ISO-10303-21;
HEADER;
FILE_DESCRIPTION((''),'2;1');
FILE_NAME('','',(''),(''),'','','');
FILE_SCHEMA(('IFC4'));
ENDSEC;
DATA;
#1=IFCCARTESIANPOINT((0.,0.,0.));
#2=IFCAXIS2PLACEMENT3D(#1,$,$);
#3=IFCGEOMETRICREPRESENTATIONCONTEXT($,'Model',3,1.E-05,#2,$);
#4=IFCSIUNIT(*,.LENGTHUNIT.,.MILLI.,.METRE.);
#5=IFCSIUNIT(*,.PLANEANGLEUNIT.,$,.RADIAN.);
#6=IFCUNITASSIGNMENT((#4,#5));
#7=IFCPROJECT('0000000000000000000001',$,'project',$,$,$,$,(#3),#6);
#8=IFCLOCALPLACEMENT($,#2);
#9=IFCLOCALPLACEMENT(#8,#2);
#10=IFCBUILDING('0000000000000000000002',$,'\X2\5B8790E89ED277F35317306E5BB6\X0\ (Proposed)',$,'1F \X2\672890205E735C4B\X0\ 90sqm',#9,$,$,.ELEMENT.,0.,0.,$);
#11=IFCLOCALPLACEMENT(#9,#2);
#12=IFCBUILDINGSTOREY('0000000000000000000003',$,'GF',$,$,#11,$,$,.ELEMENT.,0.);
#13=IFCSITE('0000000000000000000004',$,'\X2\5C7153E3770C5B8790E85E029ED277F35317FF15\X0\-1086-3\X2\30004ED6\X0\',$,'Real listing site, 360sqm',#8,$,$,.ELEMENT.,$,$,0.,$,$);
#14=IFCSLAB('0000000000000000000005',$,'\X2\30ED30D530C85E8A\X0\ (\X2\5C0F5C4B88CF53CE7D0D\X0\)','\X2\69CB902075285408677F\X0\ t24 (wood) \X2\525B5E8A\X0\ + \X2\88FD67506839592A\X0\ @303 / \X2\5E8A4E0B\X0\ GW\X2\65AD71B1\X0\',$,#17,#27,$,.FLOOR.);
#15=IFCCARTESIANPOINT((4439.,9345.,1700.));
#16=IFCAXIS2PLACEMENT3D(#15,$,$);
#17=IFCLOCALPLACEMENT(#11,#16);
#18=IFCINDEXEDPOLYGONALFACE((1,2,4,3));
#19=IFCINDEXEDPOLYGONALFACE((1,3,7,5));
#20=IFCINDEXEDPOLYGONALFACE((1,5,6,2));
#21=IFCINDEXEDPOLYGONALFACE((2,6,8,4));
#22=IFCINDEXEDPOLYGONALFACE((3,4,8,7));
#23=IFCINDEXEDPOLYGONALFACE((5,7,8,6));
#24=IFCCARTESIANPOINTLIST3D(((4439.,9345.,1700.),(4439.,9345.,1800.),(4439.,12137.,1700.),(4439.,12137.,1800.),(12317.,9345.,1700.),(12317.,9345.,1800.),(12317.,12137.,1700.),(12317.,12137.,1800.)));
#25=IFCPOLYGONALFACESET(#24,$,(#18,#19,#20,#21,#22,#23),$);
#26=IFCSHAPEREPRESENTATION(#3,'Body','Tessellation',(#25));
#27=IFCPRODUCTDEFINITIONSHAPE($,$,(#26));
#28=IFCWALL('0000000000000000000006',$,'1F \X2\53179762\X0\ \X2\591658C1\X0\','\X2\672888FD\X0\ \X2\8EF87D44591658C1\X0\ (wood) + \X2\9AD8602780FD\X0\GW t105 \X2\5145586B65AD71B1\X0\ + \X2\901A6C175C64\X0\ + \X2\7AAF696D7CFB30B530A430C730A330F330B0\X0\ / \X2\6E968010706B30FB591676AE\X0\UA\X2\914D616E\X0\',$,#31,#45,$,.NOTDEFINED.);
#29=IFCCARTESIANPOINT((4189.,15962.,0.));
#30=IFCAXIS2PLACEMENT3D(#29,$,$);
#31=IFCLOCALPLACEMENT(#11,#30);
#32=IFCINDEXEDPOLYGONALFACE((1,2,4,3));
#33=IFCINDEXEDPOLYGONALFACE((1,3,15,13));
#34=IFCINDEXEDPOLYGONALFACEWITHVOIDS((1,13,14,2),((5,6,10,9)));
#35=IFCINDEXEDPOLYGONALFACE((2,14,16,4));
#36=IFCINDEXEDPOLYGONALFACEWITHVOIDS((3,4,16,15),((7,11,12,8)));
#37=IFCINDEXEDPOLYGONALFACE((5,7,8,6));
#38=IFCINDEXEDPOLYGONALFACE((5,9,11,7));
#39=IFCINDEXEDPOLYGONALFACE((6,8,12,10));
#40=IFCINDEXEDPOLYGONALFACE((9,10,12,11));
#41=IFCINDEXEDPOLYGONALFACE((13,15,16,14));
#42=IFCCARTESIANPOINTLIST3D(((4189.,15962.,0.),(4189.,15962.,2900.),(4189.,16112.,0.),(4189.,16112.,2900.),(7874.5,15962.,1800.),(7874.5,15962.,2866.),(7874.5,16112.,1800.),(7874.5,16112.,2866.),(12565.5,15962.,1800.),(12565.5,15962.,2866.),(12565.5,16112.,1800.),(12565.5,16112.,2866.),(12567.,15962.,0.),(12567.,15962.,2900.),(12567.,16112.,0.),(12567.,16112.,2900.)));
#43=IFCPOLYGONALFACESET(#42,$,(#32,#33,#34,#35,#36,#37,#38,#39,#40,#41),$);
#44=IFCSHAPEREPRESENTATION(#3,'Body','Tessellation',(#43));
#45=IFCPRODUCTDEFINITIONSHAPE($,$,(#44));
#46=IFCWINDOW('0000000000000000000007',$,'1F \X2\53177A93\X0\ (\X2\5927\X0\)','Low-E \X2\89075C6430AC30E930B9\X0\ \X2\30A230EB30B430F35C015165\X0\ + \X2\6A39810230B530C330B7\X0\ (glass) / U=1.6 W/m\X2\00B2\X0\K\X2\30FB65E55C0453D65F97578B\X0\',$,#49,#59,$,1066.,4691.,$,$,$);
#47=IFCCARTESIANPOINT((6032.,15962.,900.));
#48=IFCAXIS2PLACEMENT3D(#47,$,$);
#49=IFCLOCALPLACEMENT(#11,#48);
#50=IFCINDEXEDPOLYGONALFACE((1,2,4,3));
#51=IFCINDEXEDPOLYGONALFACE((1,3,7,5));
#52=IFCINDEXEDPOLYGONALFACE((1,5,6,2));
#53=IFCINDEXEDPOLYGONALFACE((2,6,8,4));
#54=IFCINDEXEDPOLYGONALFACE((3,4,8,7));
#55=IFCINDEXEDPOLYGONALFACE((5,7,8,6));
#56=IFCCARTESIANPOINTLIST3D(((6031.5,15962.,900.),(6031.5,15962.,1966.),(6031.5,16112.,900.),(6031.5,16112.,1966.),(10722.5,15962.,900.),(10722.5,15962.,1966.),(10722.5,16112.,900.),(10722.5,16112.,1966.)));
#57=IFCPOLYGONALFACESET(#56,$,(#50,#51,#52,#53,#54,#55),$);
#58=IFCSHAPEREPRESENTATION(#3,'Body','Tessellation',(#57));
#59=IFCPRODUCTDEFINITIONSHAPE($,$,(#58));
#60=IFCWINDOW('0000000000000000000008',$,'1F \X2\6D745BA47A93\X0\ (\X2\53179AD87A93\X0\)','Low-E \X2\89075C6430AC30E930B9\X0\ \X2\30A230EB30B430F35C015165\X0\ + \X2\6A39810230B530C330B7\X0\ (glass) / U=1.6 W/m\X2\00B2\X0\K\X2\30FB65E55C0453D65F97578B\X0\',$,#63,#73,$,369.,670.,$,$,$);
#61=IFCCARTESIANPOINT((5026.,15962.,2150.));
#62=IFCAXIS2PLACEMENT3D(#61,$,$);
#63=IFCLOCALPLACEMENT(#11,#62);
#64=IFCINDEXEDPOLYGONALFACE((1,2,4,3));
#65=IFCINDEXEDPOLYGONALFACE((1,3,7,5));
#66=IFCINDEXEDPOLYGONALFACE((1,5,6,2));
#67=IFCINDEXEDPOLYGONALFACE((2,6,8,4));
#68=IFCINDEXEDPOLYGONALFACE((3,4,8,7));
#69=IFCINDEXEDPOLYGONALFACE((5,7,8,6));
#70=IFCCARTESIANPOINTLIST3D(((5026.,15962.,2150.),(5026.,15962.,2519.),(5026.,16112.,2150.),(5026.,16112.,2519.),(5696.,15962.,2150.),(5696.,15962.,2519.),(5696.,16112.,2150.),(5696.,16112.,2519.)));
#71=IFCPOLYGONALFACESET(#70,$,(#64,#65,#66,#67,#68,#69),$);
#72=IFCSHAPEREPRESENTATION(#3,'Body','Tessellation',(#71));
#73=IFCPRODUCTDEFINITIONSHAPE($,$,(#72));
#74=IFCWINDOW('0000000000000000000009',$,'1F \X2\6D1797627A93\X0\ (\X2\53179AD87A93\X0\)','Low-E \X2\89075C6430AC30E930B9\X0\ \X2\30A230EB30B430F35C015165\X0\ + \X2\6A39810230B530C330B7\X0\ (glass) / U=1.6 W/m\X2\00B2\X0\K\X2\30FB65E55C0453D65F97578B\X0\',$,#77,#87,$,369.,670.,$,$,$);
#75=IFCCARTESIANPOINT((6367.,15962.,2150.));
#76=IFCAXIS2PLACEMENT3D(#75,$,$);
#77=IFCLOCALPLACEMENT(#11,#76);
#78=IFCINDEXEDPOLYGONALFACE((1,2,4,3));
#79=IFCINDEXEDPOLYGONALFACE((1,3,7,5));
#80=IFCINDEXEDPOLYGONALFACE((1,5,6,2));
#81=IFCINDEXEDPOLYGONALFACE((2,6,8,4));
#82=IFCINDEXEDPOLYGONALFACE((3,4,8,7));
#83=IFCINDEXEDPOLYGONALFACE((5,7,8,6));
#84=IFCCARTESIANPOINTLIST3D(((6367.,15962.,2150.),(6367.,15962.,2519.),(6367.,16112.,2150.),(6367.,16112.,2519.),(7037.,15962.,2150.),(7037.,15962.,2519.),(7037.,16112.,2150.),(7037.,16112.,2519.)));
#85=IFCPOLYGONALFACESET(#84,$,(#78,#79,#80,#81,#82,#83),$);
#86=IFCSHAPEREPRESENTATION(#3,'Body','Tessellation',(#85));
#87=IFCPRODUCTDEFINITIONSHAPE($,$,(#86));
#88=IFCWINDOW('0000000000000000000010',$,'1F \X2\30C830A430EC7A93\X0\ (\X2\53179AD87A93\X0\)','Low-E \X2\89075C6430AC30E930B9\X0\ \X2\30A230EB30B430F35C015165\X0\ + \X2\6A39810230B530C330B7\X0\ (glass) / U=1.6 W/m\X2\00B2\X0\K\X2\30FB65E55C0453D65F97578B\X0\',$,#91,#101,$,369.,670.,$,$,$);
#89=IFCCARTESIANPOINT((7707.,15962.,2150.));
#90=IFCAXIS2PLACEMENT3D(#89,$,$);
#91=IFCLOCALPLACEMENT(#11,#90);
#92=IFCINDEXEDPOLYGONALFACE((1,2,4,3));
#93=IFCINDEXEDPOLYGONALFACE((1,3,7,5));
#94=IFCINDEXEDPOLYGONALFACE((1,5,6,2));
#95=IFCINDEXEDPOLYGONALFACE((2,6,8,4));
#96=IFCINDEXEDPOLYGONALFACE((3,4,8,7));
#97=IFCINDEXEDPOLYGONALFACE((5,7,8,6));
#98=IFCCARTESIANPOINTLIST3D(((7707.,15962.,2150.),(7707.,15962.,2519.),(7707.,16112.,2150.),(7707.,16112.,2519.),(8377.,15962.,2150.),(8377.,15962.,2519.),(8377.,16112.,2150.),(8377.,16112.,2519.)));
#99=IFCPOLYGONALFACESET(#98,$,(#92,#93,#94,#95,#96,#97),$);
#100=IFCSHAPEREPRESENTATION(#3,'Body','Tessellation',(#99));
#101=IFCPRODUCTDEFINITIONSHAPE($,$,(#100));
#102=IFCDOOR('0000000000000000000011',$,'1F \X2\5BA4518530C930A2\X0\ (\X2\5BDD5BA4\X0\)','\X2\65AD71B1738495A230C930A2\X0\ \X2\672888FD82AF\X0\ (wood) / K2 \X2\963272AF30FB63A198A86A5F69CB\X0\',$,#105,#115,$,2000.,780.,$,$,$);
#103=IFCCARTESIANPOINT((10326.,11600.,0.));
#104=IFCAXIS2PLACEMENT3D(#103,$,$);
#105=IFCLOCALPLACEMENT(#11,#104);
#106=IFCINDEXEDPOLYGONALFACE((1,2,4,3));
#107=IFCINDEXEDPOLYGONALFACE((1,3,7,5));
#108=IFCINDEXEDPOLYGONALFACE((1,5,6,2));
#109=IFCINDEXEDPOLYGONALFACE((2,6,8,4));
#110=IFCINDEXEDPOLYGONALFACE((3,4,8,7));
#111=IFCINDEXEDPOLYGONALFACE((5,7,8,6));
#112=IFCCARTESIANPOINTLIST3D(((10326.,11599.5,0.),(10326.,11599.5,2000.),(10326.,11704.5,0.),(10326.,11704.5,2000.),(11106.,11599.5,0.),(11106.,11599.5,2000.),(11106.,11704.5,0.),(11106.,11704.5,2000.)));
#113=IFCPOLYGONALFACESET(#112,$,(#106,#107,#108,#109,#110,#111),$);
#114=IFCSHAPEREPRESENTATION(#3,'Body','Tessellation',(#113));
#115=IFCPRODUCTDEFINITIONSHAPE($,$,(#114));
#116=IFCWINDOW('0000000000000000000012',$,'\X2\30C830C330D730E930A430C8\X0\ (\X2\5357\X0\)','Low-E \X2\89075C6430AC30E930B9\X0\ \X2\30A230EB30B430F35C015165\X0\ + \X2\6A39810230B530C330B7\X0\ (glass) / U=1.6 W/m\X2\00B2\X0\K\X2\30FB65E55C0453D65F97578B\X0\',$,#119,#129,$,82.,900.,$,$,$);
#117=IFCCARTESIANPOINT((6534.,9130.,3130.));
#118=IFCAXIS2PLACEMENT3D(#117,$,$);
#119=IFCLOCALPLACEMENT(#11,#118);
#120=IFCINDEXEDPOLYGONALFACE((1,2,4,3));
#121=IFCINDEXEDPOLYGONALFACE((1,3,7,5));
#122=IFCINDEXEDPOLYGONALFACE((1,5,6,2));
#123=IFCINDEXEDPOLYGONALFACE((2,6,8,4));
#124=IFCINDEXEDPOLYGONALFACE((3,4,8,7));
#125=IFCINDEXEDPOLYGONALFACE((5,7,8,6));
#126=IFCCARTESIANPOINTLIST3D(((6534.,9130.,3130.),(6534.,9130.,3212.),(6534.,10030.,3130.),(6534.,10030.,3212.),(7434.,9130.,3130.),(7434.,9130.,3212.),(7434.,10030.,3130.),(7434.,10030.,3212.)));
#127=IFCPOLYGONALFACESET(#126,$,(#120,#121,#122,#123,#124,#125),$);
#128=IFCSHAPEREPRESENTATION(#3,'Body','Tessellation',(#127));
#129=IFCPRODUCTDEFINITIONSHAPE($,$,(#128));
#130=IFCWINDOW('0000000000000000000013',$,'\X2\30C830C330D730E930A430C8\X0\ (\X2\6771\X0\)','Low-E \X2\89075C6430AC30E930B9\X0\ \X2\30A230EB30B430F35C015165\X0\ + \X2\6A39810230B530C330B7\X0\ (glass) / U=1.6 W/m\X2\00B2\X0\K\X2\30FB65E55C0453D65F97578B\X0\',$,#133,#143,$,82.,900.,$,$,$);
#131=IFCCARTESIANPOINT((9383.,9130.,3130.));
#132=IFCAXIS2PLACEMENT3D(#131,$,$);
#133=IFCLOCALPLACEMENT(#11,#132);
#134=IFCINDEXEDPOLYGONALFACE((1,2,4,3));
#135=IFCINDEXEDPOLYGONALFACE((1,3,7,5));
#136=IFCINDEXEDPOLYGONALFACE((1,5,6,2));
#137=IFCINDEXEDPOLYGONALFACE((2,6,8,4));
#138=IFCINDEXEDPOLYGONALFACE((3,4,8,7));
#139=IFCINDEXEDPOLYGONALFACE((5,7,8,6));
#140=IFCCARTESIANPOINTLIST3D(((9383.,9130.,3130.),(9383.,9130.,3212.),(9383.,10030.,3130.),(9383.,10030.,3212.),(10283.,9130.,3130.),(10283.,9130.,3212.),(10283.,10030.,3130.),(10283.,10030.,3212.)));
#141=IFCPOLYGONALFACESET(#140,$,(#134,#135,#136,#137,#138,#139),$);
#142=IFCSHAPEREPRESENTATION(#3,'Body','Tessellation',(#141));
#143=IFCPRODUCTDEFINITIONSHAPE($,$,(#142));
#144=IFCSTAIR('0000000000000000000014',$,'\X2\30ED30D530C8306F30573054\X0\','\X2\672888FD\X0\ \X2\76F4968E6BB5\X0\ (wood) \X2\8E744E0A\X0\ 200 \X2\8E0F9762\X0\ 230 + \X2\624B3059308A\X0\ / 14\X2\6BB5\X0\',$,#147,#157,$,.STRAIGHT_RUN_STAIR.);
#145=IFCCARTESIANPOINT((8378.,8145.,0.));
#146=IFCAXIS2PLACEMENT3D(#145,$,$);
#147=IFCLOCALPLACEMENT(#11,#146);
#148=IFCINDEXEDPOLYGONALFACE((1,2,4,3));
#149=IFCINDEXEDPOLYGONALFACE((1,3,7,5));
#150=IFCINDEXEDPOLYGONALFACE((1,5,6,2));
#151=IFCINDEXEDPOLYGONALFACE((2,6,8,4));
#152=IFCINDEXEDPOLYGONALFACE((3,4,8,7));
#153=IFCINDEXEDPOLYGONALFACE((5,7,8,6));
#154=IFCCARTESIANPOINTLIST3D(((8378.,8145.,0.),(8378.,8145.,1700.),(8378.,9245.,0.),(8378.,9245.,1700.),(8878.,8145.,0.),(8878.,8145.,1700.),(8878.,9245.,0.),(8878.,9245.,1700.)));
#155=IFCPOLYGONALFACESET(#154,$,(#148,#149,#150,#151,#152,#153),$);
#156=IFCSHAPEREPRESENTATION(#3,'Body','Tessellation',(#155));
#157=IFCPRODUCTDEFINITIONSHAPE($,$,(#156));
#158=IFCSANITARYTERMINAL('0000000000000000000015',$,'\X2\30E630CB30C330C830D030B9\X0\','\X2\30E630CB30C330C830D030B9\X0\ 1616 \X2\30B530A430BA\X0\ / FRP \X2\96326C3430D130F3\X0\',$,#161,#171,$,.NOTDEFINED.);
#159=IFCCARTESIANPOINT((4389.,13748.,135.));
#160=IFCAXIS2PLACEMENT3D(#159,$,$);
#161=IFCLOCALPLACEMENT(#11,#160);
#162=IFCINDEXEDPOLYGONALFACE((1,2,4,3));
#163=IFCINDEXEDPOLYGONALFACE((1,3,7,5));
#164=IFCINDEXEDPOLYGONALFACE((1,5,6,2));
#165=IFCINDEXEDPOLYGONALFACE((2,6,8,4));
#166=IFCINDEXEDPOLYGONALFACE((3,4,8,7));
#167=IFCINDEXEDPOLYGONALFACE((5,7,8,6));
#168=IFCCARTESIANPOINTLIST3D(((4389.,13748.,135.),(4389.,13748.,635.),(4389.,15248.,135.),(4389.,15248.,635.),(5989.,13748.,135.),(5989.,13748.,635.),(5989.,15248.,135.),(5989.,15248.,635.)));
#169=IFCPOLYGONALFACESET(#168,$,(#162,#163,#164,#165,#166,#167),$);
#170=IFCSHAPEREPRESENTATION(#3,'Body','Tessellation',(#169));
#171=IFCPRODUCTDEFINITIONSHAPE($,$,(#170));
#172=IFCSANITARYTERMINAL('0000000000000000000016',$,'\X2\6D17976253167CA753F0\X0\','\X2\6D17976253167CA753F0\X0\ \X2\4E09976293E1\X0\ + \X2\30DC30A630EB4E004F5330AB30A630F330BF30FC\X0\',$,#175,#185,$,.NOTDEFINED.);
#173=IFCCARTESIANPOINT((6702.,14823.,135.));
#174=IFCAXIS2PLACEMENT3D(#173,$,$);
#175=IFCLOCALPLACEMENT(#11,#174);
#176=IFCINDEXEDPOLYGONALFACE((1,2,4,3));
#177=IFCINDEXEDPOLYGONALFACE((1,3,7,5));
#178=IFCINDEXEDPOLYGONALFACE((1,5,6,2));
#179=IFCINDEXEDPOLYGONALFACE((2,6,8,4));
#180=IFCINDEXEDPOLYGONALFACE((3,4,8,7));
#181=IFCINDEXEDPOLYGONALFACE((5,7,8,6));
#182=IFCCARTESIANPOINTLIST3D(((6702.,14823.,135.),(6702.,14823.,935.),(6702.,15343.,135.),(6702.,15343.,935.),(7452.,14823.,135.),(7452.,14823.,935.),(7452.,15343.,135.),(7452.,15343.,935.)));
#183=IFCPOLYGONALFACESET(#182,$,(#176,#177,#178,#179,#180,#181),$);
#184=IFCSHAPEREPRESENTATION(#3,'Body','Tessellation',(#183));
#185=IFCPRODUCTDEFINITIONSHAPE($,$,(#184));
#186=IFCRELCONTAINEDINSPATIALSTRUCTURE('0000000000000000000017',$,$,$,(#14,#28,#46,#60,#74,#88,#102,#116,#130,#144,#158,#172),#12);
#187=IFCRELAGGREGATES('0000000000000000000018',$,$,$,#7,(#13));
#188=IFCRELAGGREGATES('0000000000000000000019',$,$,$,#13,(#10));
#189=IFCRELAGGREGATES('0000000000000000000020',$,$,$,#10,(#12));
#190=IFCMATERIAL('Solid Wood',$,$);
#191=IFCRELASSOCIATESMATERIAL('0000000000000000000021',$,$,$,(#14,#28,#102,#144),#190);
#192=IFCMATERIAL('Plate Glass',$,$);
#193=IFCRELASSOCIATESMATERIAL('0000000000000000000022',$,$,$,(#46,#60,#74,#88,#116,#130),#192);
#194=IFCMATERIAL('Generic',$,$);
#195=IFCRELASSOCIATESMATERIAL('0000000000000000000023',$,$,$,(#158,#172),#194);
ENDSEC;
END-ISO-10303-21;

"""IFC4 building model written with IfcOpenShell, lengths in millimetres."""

from ifc_helpers import new_model, si_unit, frame, frame_2d, origin, place, context, project, spatial, rectangle, extrude, material, element, fill, save


model = new_model("IFC4")

# Units and contexts
model_context = context("Model", 3, precision=1e-05, world=origin())
ifc_project = project(units=[si_unit("LENGTHUNIT", "METRE", prefix="MILLI"), si_unit("PLANEANGLEUNIT", "RADIAN")], contexts=[model_context])

# Site, building, storey
site_placement = place(None, origin())
site = spatial("IfcSite", under=ifc_project, at=site_placement, Name="山口県宇部市黒石北５-1086-3　他", ObjectType="Real listing site, 360sqm", CompositionType="ELEMENT", RefElevation=0.0)
building_placement = place(site_placement, origin())
building = spatial("IfcBuilding", under=site, at=building_placement, Name="宇部黒石北の家 (Proposed)", ObjectType="1F 木造平屋 90sqm", CompositionType="ELEMENT", ElevationOfRefHeight=0.0, ElevationOfTerrain=0.0)
storey_placement = place(building_placement, origin())
storey = spatial("IfcBuildingStorey", under=building, at=storey_placement, Name="GF", CompositionType="ELEMENT", Elevation=0.0)

# Slab
ifc_material_1 = material(Name="Solid Wood")
slab_placement = place(storey_placement, frame((4439.0, 9345.0, 1700.0)))
element("IfcSlab", 1, at=slab_placement, inside=storey, material=ifc_material_1, Name="ロフト床 (小屋裏収納)", Description="構造用合板 t24 (wood) 剛床 + 製材根太 @303 / 床下 GW断熱", PredefinedType="FLOOR", context=model_context, shape_type="SweptSolid", body=[
    extrude(rectangle(XDim=7878.0, YDim=2792.0, at=frame_2d((3939.0, 1396.0))), frame((4439.0, 9345.0, 1700.0)), (0.0, 0.0, 1.0), 100.0),
])

# Wall, openings, windows
wall_1_placement = place(storey_placement, frame((4189.0, 15962.0, 0.0)))
wall_1 = element("IfcWall", 2, at=wall_1_placement, inside=storey, material=ifc_material_1, Name="1F 北面 外壁", Description="木製 軸組外壁 (wood) + 高性能GW t105 充填断熱 + 通気層 + 窯業系サイディング / 準耐火・外皮UA配慮", PredefinedType="NOTDEFINED", context=model_context, shape_type="SweptSolid", body=[
    extrude(rectangle(XDim=8378.0, YDim=150.0, at=frame_2d((4189.0, 75.0))), frame((4189.0, 15962.0, 0.0)), (0.0, 0.0, 1.0), 2900.0),
])
opening_1_placement = place(storey_placement, frame((6032.0, 15962.0, 900.0)))
opening_1 = element("IfcOpeningElement", 3, at=opening_1_placement, cuts=wall_1, PredefinedType="NOTDEFINED", context=model_context, shape_type="SweptSolid", body=[
    extrude(rectangle(XDim=4691.0, YDim=150.0, at=frame_2d((2345.0, 75.0))), frame((6032.0, 15962.0, 900.0)), (0.0, 0.0, 1.0), 1066.0),
])
opening_2_placement = place(storey_placement, frame((5026.0, 15962.0, 2150.0)))
opening_2 = element("IfcOpeningElement", 4, at=opening_2_placement, cuts=wall_1, PredefinedType="NOTDEFINED", context=model_context, shape_type="SweptSolid", body=[
    extrude(rectangle(XDim=670.0, YDim=150.0, at=frame_2d((335.0, 75.0))), frame((5026.0, 15962.0, 2150.0)), (0.0, 0.0, 1.0), 369.0),
])
opening_3_placement = place(storey_placement, frame((6367.0, 15962.0, 2150.0)))
opening_3 = element("IfcOpeningElement", 5, at=opening_3_placement, cuts=wall_1, PredefinedType="NOTDEFINED", context=model_context, shape_type="SweptSolid", body=[
    extrude(rectangle(XDim=670.0, YDim=150.0, at=frame_2d((335.0, 75.0))), frame((6367.0, 15962.0, 2150.0)), (0.0, 0.0, 1.0), 369.0),
])
opening_4_placement = place(storey_placement, frame((7707.0, 15962.0, 2150.0)))
opening_4 = element("IfcOpeningElement", 6, at=opening_4_placement, cuts=wall_1, PredefinedType="NOTDEFINED", context=model_context, shape_type="SweptSolid", body=[
    extrude(rectangle(XDim=670.0, YDim=150.0, at=frame_2d((335.0, 75.0))), frame((7707.0, 15962.0, 2150.0)), (0.0, 0.0, 1.0), 369.0),
])
ifc_material_2 = material(Name="Plate Glass")
window_1_placement = place(storey_placement, frame((6032.0, 15962.0, 900.0)))
window_1 = element("IfcWindow", 7, at=window_1_placement, inside=storey, material=ifc_material_2, Name="1F 北窓 (大)", Description="Low-E 複層ガラス アルゴン封入 + 樹脂サッシ (glass) / U=1.6 W/m²K・日射取得型", OverallHeight=1066.0, OverallWidth=4691.0, context=model_context, shape_type="SweptSolid", body=[
    extrude(rectangle(XDim=4691.0, YDim=150.0, at=frame_2d((2345.0, 75.0))), frame((6032.0, 15962.0, 900.0)), (0.0, 0.0, 1.0), 1066.0),
])
fill(opening_1, window_1)
window_2_placement = place(storey_placement, frame((5026.0, 15962.0, 2150.0)))
window_2 = element("IfcWindow", 8, at=window_2_placement, inside=storey, material=ifc_material_2, Name="1F 浴室窓 (北高窓)", Description="Low-E 複層ガラス アルゴン封入 + 樹脂サッシ (glass) / U=1.6 W/m²K・日射取得型", OverallHeight=369.0, OverallWidth=670.0, context=model_context, shape_type="SweptSolid", body=[
    extrude(rectangle(XDim=670.0, YDim=150.0, at=frame_2d((335.0, 75.0))), frame((5026.0, 15962.0, 2150.0)), (0.0, 0.0, 1.0), 369.0),
])
fill(opening_2, window_2)
window_3_placement = place(storey_placement, frame((6367.0, 15962.0, 2150.0)))
window_3 = element("IfcWindow", 9, at=window_3_placement, inside=storey, material=ifc_material_2, Name="1F 洗面窓 (北高窓)", Description="Low-E 複層ガラス アルゴン封入 + 樹脂サッシ (glass) / U=1.6 W/m²K・日射取得型", OverallHeight=369.0, OverallWidth=670.0, context=model_context, shape_type="SweptSolid", body=[
    extrude(rectangle(XDim=670.0, YDim=150.0, at=frame_2d((335.0, 75.0))), frame((6367.0, 15962.0, 2150.0)), (0.0, 0.0, 1.0), 369.0),
])
fill(opening_3, window_3)
window_4_placement = place(storey_placement, frame((7707.0, 15962.0, 2150.0)))
window_4 = element("IfcWindow", 10, at=window_4_placement, inside=storey, material=ifc_material_2, Name="1F トイレ窓 (北高窓)", Description="Low-E 複層ガラス アルゴン封入 + 樹脂サッシ (glass) / U=1.6 W/m²K・日射取得型", OverallHeight=369.0, OverallWidth=670.0, context=model_context, shape_type="SweptSolid", body=[
    extrude(rectangle(XDim=670.0, YDim=150.0, at=frame_2d((335.0, 75.0))), frame((7707.0, 15962.0, 2150.0)), (0.0, 0.0, 1.0), 369.0),
])
fill(opening_4, window_4)

# Door
door_1_placement = place(storey_placement, frame((10326.0, 11600.0, 0.0)))
element("IfcDoor", 11, at=door_1_placement, inside=storey, material=ifc_material_1, Name="1F 室内ドア (寝室)", Description="断熱玄関ドア 木製芯 (wood) / K2 防犯・採風機構", OverallHeight=2000.0, OverallWidth=780.0, context=model_context, shape_type="SweptSolid", body=[
    extrude(rectangle(XDim=780.0, YDim=105.0, at=frame_2d((390.0, 52.0))), frame((10326.0, 11600.0, 0.0)), (0.0, 0.0, 1.0), 2000.0),
])

# Windows
window_5_placement = place(storey_placement, frame((6534.0, 9130.0, 3130.0)))
element("IfcWindow", 12, at=window_5_placement, inside=storey, material=ifc_material_2, Name="トップライト (南)", Description="Low-E 複層ガラス アルゴン封入 + 樹脂サッシ (glass) / U=1.6 W/m²K・日射取得型", OverallHeight=82.0, OverallWidth=900.0, context=model_context, shape_type="SweptSolid", body=[
    extrude(rectangle(XDim=900.0, YDim=900.0, at=frame_2d((450.0, 450.0))), frame((6534.0, 9130.0, 3130.0)), (0.0, 0.0, 1.0), 82.0),
])
window_6_placement = place(storey_placement, frame((9383.0, 9130.0, 3130.0)))
element("IfcWindow", 13, at=window_6_placement, inside=storey, material=ifc_material_2, Name="トップライト (東)", Description="Low-E 複層ガラス アルゴン封入 + 樹脂サッシ (glass) / U=1.6 W/m²K・日射取得型", OverallHeight=82.0, OverallWidth=900.0, context=model_context, shape_type="SweptSolid", body=[
    extrude(rectangle(XDim=900.0, YDim=900.0, at=frame_2d((450.0, 450.0))), frame((9383.0, 9130.0, 3130.0)), (0.0, 0.0, 1.0), 82.0),
])

# Stair
stair_placement = place(storey_placement, frame((8378.0, 8145.0, 0.0)))
element("IfcStair", 14, at=stair_placement, inside=storey, material=ifc_material_1, Name="ロフトはしご", Description="木製 直階段 (wood) 蹴上 200 踏面 230 + 手すり / 14段", PredefinedType="STRAIGHT_RUN_STAIR", context=model_context, shape_type="SweptSolid", body=[
    extrude(rectangle(XDim=500.0, YDim=1100.0, at=frame_2d((250.0, 550.0))), frame((8378.0, 8145.0, 0.0)), (0.0, 0.0, 1.0), 1700.0),
])

# Sanitary terminals
ifc_material_3 = material(Name="Generic")
sanitary_terminal_1_placement = place(storey_placement, frame((4389.0, 13748.0, 135.0)))
element("IfcSanitaryTerminal", 15, at=sanitary_terminal_1_placement, inside=storey, material=ifc_material_3, Name="ユニットバス", Description="ユニットバス 1616 サイズ / FRP 防水パン", PredefinedType="NOTDEFINED", context=model_context, shape_type="SweptSolid", body=[
    extrude(rectangle(XDim=1600.0, YDim=1500.0, at=frame_2d((800.0, 750.0))), frame((4389.0, 13748.0, 135.0)), (0.0, 0.0, 1.0), 500.0),
])
sanitary_terminal_2_placement = place(storey_placement, frame((6702.0, 14823.0, 135.0)))
element("IfcSanitaryTerminal", 16, at=sanitary_terminal_2_placement, inside=storey, material=ifc_material_3, Name="洗面化粧台", Description="洗面化粧台 三面鏡 + ボウル一体カウンター", PredefinedType="NOTDEFINED", context=model_context, shape_type="SweptSolid", body=[
    extrude(rectangle(XDim=750.0, YDim=520.0, at=frame_2d((375.0, 260.0))), frame((6702.0, 14823.0, 135.0)), (0.0, 0.0, 1.0), 800.0),
])

save(model, "model.ifc")
